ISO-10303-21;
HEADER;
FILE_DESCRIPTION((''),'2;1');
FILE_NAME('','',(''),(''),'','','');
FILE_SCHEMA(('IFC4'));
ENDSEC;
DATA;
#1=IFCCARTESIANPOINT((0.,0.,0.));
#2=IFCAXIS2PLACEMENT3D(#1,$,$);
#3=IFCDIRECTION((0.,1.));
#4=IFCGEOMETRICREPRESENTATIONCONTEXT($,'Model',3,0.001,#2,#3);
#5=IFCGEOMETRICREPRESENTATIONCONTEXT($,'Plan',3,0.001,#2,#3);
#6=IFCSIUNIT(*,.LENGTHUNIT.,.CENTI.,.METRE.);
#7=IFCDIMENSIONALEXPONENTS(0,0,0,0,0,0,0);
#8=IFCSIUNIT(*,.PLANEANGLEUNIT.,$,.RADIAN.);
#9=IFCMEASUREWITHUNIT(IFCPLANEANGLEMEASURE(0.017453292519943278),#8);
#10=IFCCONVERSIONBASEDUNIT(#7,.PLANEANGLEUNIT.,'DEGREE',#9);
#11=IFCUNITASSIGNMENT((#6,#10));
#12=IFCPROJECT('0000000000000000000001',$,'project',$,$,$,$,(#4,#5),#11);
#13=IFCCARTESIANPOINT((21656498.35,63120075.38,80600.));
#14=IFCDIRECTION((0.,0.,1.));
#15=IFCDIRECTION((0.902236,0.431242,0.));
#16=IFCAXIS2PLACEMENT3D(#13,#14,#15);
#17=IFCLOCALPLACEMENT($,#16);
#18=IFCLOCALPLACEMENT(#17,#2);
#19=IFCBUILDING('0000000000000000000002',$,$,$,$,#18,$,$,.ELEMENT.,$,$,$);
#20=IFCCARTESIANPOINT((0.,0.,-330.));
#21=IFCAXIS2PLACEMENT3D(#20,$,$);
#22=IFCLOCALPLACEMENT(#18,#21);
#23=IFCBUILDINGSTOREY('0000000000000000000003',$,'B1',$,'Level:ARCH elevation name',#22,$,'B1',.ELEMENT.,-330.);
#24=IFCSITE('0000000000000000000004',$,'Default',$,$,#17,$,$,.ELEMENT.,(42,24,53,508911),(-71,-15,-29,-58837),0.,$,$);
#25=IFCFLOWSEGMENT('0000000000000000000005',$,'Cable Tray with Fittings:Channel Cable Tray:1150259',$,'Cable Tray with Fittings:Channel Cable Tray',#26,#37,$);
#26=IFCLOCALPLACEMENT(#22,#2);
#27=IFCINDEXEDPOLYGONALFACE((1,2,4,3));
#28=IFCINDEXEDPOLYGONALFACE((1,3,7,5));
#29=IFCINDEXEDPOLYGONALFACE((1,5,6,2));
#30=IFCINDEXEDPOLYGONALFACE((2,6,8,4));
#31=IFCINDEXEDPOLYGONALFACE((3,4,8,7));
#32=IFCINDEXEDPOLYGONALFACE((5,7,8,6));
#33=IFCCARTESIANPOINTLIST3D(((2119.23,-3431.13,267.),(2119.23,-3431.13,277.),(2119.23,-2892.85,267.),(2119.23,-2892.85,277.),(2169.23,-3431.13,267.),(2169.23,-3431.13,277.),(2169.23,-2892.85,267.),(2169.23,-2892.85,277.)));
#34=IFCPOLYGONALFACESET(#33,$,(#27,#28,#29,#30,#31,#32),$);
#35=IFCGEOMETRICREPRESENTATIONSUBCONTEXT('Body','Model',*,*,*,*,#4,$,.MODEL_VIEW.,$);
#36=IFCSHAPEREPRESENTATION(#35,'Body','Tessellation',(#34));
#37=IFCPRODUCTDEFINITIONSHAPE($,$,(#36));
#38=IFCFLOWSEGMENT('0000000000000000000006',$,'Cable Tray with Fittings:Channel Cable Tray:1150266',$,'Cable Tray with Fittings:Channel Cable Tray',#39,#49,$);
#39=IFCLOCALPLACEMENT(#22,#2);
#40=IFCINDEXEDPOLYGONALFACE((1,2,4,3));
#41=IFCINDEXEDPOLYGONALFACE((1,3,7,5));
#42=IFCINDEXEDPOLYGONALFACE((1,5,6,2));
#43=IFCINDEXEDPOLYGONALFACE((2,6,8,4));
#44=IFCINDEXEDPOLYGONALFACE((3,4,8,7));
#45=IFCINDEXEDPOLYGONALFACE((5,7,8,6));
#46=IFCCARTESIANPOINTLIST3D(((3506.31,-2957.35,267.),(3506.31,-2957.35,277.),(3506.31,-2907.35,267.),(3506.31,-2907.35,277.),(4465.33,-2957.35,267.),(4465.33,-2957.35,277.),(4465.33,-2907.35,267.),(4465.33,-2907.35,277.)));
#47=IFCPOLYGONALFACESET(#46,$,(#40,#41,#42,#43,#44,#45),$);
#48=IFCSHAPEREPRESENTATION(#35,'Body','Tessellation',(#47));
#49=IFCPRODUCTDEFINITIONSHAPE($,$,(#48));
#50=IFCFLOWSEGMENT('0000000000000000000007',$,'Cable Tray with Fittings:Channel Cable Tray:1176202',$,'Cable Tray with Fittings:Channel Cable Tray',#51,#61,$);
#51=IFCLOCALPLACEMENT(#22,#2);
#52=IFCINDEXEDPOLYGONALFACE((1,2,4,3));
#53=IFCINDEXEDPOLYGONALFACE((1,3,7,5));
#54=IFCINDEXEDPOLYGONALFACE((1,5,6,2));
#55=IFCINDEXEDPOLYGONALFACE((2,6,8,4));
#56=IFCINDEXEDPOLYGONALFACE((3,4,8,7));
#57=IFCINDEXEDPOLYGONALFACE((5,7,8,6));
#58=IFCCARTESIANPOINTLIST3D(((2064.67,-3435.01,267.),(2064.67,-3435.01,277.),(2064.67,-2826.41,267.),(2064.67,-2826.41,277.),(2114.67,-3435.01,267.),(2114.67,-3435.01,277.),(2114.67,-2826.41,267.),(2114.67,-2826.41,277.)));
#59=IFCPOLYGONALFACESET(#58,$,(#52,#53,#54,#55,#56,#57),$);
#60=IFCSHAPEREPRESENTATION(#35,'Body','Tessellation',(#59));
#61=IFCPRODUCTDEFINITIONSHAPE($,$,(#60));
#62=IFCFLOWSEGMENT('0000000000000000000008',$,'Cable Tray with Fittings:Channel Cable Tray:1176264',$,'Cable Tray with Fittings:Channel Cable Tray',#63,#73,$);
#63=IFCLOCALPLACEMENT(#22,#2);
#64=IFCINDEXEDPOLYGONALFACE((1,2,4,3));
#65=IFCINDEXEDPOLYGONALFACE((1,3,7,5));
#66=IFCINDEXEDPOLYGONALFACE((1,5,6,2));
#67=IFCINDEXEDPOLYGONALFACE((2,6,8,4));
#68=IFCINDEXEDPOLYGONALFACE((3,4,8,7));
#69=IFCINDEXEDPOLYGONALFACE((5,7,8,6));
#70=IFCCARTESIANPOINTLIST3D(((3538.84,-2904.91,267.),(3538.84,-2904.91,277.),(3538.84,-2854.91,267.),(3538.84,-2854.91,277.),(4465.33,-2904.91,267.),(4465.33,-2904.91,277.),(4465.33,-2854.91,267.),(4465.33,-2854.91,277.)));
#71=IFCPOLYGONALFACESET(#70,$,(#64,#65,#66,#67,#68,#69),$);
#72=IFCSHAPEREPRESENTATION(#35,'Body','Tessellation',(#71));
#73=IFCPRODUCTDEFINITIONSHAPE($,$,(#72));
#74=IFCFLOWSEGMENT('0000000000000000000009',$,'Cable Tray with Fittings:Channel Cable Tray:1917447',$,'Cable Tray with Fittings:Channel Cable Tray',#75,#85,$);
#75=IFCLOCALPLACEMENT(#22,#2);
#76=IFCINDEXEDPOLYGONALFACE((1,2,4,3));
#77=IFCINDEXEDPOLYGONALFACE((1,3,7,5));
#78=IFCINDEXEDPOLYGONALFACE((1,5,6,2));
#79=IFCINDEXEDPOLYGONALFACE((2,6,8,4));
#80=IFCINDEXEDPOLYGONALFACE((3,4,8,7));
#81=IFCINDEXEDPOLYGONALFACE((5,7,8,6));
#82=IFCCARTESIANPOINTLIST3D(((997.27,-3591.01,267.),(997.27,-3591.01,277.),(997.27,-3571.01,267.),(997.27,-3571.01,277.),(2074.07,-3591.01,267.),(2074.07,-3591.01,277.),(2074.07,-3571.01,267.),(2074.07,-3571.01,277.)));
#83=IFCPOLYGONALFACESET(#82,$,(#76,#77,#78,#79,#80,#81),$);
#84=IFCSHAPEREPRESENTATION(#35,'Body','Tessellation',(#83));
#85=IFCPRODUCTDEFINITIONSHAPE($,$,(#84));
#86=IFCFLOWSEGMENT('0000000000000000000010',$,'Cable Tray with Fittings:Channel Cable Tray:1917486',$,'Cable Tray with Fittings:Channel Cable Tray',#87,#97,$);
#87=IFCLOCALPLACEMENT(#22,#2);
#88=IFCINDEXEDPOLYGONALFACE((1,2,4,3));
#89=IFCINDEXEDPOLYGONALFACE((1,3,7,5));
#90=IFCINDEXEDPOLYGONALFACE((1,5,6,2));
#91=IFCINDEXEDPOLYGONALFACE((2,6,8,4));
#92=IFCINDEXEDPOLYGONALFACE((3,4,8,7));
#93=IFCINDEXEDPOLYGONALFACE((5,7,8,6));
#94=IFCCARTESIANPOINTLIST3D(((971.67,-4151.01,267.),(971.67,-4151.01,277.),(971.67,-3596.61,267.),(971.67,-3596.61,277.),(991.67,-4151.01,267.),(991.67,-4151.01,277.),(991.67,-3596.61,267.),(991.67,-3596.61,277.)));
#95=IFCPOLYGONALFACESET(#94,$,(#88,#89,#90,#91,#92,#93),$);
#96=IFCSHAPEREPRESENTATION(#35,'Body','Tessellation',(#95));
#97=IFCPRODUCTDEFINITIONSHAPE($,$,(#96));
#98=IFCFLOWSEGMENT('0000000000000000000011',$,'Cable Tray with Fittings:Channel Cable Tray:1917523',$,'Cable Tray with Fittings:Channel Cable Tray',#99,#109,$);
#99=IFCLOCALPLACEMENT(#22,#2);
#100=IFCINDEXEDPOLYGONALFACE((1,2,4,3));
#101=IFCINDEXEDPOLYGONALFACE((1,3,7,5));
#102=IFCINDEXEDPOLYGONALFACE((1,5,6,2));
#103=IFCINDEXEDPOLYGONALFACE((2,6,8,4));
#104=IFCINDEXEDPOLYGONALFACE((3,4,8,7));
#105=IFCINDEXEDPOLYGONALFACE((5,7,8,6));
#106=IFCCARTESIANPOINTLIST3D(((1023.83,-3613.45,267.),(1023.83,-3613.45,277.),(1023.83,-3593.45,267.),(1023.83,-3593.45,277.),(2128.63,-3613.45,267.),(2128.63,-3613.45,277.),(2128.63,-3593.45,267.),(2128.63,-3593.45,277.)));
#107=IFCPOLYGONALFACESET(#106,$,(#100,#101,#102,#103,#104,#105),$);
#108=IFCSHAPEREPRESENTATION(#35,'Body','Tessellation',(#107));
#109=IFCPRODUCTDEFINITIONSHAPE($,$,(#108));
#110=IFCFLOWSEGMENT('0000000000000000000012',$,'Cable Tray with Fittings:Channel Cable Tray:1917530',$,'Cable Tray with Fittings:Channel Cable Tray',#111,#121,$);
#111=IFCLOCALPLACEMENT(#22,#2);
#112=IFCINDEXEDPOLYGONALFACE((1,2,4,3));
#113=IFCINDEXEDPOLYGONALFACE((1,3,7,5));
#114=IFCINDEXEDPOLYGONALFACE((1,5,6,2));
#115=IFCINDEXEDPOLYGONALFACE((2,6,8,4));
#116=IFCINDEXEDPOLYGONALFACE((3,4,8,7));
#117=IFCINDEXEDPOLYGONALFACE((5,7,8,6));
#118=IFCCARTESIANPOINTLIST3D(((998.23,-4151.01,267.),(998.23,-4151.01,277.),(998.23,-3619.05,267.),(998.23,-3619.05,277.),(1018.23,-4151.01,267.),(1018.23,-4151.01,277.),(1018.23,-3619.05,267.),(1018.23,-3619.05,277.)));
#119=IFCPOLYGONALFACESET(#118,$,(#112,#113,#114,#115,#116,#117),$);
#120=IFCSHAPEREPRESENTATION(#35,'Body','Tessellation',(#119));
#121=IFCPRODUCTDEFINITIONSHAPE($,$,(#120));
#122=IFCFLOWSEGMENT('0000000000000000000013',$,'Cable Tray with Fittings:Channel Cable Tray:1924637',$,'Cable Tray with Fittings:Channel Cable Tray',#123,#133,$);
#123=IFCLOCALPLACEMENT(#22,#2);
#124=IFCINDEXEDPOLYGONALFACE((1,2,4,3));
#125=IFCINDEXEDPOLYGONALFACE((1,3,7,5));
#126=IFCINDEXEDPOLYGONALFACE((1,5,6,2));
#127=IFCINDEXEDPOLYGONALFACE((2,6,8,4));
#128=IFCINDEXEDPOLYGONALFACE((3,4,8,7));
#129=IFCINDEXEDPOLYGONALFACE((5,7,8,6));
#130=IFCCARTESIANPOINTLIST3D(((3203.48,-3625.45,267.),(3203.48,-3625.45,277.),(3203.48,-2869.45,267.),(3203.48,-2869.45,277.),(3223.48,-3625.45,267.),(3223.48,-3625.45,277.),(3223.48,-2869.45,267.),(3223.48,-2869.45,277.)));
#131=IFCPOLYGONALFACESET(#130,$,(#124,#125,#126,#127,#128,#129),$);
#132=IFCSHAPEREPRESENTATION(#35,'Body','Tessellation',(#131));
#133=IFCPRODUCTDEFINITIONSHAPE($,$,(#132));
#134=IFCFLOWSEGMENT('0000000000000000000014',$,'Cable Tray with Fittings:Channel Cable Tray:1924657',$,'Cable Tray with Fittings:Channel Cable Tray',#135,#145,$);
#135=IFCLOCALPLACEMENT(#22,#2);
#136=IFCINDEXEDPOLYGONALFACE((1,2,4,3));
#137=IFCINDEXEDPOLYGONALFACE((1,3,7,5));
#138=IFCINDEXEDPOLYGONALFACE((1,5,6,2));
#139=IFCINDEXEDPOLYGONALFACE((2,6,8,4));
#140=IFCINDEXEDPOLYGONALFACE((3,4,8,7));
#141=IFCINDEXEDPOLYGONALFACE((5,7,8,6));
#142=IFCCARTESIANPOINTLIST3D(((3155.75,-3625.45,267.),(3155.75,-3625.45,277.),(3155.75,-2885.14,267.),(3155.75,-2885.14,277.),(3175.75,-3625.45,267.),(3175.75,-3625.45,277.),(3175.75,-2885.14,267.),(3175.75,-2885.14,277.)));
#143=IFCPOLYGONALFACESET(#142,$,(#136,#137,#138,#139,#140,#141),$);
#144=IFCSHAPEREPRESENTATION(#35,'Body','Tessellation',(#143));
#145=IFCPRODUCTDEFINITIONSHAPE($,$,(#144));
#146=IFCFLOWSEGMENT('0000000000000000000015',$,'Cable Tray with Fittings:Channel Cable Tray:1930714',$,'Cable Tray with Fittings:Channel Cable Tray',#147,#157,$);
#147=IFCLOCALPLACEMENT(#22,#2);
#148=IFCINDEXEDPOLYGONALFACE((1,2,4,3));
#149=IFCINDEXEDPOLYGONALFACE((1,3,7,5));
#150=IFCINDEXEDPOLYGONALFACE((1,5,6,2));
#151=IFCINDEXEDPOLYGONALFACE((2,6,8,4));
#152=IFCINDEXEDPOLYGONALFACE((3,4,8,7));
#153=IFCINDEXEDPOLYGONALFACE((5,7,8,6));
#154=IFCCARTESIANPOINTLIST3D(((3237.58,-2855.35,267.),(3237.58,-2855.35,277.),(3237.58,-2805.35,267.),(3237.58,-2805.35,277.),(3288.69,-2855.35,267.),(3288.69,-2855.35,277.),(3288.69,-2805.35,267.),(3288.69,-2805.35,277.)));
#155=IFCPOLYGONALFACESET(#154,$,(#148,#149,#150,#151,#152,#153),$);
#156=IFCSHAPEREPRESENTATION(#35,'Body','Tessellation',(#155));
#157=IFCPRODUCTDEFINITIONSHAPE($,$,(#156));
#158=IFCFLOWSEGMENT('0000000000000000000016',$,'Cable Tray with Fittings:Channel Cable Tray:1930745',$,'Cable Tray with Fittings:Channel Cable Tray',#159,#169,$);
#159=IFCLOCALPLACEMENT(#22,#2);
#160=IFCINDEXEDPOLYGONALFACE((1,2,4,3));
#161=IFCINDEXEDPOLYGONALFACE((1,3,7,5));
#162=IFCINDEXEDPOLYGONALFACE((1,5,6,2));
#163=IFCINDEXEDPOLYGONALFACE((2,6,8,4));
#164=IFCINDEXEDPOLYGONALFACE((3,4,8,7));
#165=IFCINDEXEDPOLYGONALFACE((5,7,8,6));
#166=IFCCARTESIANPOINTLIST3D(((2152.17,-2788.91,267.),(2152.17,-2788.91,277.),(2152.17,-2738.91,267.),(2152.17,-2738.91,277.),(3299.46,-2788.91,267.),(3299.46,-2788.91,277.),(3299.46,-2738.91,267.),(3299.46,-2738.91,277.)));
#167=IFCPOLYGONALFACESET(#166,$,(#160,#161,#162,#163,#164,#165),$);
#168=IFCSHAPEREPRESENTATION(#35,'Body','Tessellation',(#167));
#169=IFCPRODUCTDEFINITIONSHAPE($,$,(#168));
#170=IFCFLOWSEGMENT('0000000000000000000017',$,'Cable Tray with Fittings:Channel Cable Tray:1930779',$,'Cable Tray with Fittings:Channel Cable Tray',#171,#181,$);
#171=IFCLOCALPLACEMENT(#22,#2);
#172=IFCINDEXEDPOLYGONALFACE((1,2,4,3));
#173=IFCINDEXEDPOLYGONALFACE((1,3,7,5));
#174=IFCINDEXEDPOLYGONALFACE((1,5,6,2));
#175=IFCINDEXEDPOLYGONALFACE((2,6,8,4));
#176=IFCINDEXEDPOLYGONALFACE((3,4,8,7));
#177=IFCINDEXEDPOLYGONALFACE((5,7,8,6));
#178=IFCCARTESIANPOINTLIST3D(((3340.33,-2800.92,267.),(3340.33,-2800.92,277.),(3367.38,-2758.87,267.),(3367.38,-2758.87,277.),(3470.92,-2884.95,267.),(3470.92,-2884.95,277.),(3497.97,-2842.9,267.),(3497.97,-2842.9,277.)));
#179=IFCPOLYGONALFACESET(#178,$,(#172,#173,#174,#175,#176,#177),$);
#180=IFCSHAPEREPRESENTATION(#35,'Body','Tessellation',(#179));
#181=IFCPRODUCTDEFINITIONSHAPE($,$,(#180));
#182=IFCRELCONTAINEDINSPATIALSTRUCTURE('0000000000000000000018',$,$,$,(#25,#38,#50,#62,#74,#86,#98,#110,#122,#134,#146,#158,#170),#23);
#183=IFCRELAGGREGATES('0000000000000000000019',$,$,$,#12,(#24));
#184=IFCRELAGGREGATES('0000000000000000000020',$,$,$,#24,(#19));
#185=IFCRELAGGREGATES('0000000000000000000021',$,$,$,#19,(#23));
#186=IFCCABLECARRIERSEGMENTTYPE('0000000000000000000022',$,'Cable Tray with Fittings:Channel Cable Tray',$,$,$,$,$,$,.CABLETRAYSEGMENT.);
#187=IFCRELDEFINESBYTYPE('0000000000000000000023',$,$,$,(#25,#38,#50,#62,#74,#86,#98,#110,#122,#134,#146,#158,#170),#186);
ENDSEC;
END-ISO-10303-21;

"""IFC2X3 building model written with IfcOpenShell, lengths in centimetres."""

from ifc_helpers import new_model, entity, si_unit, converted_unit, direction, frame, frame_2d, origin, origin_2d_with_axis, place, context, subcontext, project, spatial, rectangle, extrude, type_object, element, save


model = new_model("IFC2X3")

# Units and contexts
model_context = context("Model", 3, precision=0.001, world=origin(), true_north=direction((0.0, 1.0)))
plan_context = context("Plan", 3, precision=0.001, world=origin(), true_north=direction((0.0, 1.0)))
body_context = subcontext(model_context, "Body", "Model", "MODEL_VIEW")
ifc_project = project(units=[si_unit("LENGTHUNIT", "METRE", prefix="CENTI"), converted_unit("PLANEANGLEUNIT", "DEGREE", entity("IfcPlaneAngleMeasure", 0.017453292519943278), si_unit("PLANEANGLEUNIT", "RADIAN"), dimensions=[0, 0, 0, 0, 0, 0, 0])], contexts=[model_context, plan_context])

# Site, building, storey
site_placement = place(None, frame((21656498.35, 63120075.38, 80600.0), z_axis=(0.0, 0.0, 1.0), x_axis=(0.902236, 0.431242, 0.0)))
site = spatial("IfcSite", under=ifc_project, at=site_placement, Name="Default", CompositionType="ELEMENT", RefLatitude=(42, 24, 53, 508911), RefLongitude=(-71, -15, -29, -58837), RefElevation=0.0)
building_placement = place(site_placement, origin())
building = spatial("IfcBuilding", under=site, at=building_placement, CompositionType="ELEMENT")
storey_placement = place(building_placement, frame((0.0, 0.0, -330.0)))
storey = spatial("IfcBuildingStorey", under=building, at=storey_placement, Name="B1", ObjectType="Level:ARCH elevation name", LongName="B1", CompositionType="ELEMENT", Elevation=-330.0)

# Flow segments
cable_carrier_segment_type = type_object("IfcCableCarrierSegmentType", Name="Cable Tray with Fittings:Channel Cable Tray", PredefinedType="CABLETRAYSEGMENT")
flow_segment_1_placement = place(storey_placement, origin())
element("IfcFlowSegment", 1, at=flow_segment_1_placement, inside=storey, type_object=cable_carrier_segment_type, Name="Cable Tray with Fittings:Channel Cable Tray:1150259", ObjectType="Cable Tray with Fittings:Channel Cable Tray", context=body_context, shape_type="SweptSolid", body=[
    extrude(rectangle(XDim=538.28, YDim=50.0, at=frame_2d((0.0, 0.0), x_axis=(1.0, 0.0))), frame((2144.23, -3161.99, 267.0), z_axis=(0.0, 0.0, 1.0), x_axis=(0.0, -1.0, 0.0)), (0.0, 0.0, 1.0), 10.0),
])
flow_segment_2_placement = place(storey_placement, origin())
element("IfcFlowSegment", 2, at=flow_segment_2_placement, inside=storey, type_object=cable_carrier_segment_type, Name="Cable Tray with Fittings:Channel Cable Tray:1150266", ObjectType="Cable Tray with Fittings:Channel Cable Tray", context=body_context, shape_type="SweptSolid", body=[
    extrude(rectangle(XDim=959.02, YDim=50.0, at=frame_2d((0.0, 0.0), x_axis=(1.0, 0.0))), frame((3985.82, -2932.35, 267.0)), (0.0, 0.0, 1.0), 10.0),
])
flow_segment_3_placement = place(storey_placement, origin())
element("IfcFlowSegment", 3, at=flow_segment_3_placement, inside=storey, type_object=cable_carrier_segment_type, Name="Cable Tray with Fittings:Channel Cable Tray:1176202", ObjectType="Cable Tray with Fittings:Channel Cable Tray", context=body_context, shape_type="SweptSolid", body=[
    extrude(rectangle(XDim=608.6, YDim=50.0, at=frame_2d((0.0, 0.0), x_axis=(1.0, 0.0))), frame((2089.67, -3130.71, 267.0), z_axis=(0.0, 0.0, 1.0), x_axis=(0.0, -1.0, 0.0)), (0.0, 0.0, 1.0), 10.0),
])
flow_segment_4_placement = place(storey_placement, origin())
element("IfcFlowSegment", 4, at=flow_segment_4_placement, inside=storey, type_object=cable_carrier_segment_type, Name="Cable Tray with Fittings:Channel Cable Tray:1176264", ObjectType="Cable Tray with Fittings:Channel Cable Tray", context=body_context, shape_type="SweptSolid", body=[
    extrude(rectangle(XDim=926.5, YDim=50.0, at=frame_2d((0.0, 0.0), x_axis=(1.0, 0.0))), frame((4002.08, -2879.91, 267.0)), (0.0, 0.0, 1.0), 10.0),
])
flow_segment_5_placement = place(storey_placement, origin())
element("IfcFlowSegment", 5, at=flow_segment_5_placement, inside=storey, type_object=cable_carrier_segment_type, Name="Cable Tray with Fittings:Channel Cable Tray:1917447", ObjectType="Cable Tray with Fittings:Channel Cable Tray", context=body_context, shape_type="SweptSolid", body=[
    extrude(rectangle(XDim=1076.8, YDim=20.0, at=origin_2d_with_axis()), frame((1535.67, -3581.01, 267.0), z_axis=(0.0, 0.0, 1.0), x_axis=(-1.0, 0.0, 0.0)), (0.0, 0.0, 1.0), 10.0),
])
flow_segment_6_placement = place(storey_placement, origin())
element("IfcFlowSegment", 6, at=flow_segment_6_placement, inside=storey, type_object=cable_carrier_segment_type, Name="Cable Tray with Fittings:Channel Cable Tray:1917486", ObjectType="Cable Tray with Fittings:Channel Cable Tray", context=body_context, shape_type="SweptSolid", body=[
    extrude(rectangle(XDim=554.4, YDim=20.0, at=frame_2d((0.0, 0.0), x_axis=(1.0, 0.0))), frame((981.67, -3873.81, 267.0), z_axis=(0.0, 0.0, 1.0), x_axis=(0.0, -1.0, 0.0)), (0.0, 0.0, 1.0), 10.0),
])
flow_segment_7_placement = place(storey_placement, origin())
element("IfcFlowSegment", 7, at=flow_segment_7_placement, inside=storey, type_object=cable_carrier_segment_type, Name="Cable Tray with Fittings:Channel Cable Tray:1917523", ObjectType="Cable Tray with Fittings:Channel Cable Tray", context=body_context, shape_type="SweptSolid", body=[
    extrude(rectangle(XDim=1104.8, YDim=20.0, at=frame_2d((0.0, 0.0), x_axis=(1.0, 0.0))), frame((1576.23, -3603.45, 267.0), z_axis=(0.0, 0.0, 1.0), x_axis=(-1.0, 0.0, 0.0)), (0.0, 0.0, 1.0), 10.0),
])
flow_segment_8_placement = place(storey_placement, origin())
element("IfcFlowSegment", 8, at=flow_segment_8_placement, inside=storey, type_object=cable_carrier_segment_type, Name="Cable Tray with Fittings:Channel Cable Tray:1917530", ObjectType="Cable Tray with Fittings:Channel Cable Tray", context=body_context, shape_type="SweptSolid", body=[
    extrude(rectangle(XDim=531.96, YDim=20.0, at=frame_2d((0.0, 0.0), x_axis=(1.0, 0.0))), frame((1008.23, -3885.03, 267.0), z_axis=(0.0, 0.0, 1.0), x_axis=(0.0, -1.0, 0.0)), (0.0, 0.0, 1.0), 10.0),
])
flow_segment_9_placement = place(storey_placement, origin())
element("IfcFlowSegment", 9, at=flow_segment_9_placement, inside=storey, type_object=cable_carrier_segment_type, Name="Cable Tray with Fittings:Channel Cable Tray:1924637", ObjectType="Cable Tray with Fittings:Channel Cable Tray", context=body_context, shape_type="SweptSolid", body=[
    extrude(rectangle(XDim=756.0, YDim=20.0, at=frame_2d((0.0, 0.0), x_axis=(1.0, 0.0))), frame((3213.48, -3247.45, 267.0), z_axis=(0.0, 0.0, 1.0), x_axis=(0.0, -1.0, 0.0)), (0.0, 0.0, 1.0), 10.0),
])
flow_segment_10_placement = place(storey_placement, origin())
element("IfcFlowSegment", 10, at=flow_segment_10_placement, inside=storey, type_object=cable_carrier_segment_type, Name="Cable Tray with Fittings:Channel Cable Tray:1924657", ObjectType="Cable Tray with Fittings:Channel Cable Tray", context=body_context, shape_type="SweptSolid", body=[
    extrude(rectangle(XDim=740.31, YDim=20.0, at=origin_2d_with_axis()), frame((3165.75, -3255.29, 267.0), z_axis=(0.0, 0.0, 1.0), x_axis=(0.0, -1.0, 0.0)), (0.0, 0.0, 1.0), 10.0),
])
flow_segment_11_placement = place(storey_placement, origin())
element("IfcFlowSegment", 11, at=flow_segment_11_placement, inside=storey, type_object=cable_carrier_segment_type, Name="Cable Tray with Fittings:Channel Cable Tray:1930714", ObjectType="Cable Tray with Fittings:Channel Cable Tray", context=body_context, shape_type="SweptSolid", body=[
    extrude(rectangle(XDim=51.11, YDim=50.0, at=frame_2d((0.0, 0.0), x_axis=(1.0, 0.0))), frame((3263.14, -2830.35, 267.0)), (0.0, 0.0, 1.0), 10.0),
])
flow_segment_12_placement = place(storey_placement, origin())
element("IfcFlowSegment", 12, at=flow_segment_12_placement, inside=storey, type_object=cable_carrier_segment_type, Name="Cable Tray with Fittings:Channel Cable Tray:1930745", ObjectType="Cable Tray with Fittings:Channel Cable Tray", context=body_context, shape_type="SweptSolid", body=[
    extrude(rectangle(XDim=1147.29, YDim=50.0, at=frame_2d((0.0, 0.0), x_axis=(1.0, 0.0))), frame((2725.82, -2763.91, 267.0), z_axis=(0.0, 0.0, 1.0), x_axis=(-1.0, 0.0, 0.0)), (0.0, 0.0, 1.0), 10.0),
])
flow_segment_13_placement = place(storey_placement, origin())
element("IfcFlowSegment", 13, at=flow_segment_13_placement, inside=storey, type_object=cable_carrier_segment_type, Name="Cable Tray with Fittings:Channel Cable Tray:1930779", ObjectType="Cable Tray with Fittings:Channel Cable Tray", context=body_context, shape_type="SweptSolid", body=[
    extrude(rectangle(XDim=155.29, YDim=50.0, at=origin_2d_with_axis()), frame((3419.15, -2821.91, 267.0), z_axis=(0.0, 0.0, 1.0), x_axis=(-0.840959, 0.541099, 0.0)), (0.0, 0.0, 1.0), 10.0),
])

save(model, "model.ifc")
